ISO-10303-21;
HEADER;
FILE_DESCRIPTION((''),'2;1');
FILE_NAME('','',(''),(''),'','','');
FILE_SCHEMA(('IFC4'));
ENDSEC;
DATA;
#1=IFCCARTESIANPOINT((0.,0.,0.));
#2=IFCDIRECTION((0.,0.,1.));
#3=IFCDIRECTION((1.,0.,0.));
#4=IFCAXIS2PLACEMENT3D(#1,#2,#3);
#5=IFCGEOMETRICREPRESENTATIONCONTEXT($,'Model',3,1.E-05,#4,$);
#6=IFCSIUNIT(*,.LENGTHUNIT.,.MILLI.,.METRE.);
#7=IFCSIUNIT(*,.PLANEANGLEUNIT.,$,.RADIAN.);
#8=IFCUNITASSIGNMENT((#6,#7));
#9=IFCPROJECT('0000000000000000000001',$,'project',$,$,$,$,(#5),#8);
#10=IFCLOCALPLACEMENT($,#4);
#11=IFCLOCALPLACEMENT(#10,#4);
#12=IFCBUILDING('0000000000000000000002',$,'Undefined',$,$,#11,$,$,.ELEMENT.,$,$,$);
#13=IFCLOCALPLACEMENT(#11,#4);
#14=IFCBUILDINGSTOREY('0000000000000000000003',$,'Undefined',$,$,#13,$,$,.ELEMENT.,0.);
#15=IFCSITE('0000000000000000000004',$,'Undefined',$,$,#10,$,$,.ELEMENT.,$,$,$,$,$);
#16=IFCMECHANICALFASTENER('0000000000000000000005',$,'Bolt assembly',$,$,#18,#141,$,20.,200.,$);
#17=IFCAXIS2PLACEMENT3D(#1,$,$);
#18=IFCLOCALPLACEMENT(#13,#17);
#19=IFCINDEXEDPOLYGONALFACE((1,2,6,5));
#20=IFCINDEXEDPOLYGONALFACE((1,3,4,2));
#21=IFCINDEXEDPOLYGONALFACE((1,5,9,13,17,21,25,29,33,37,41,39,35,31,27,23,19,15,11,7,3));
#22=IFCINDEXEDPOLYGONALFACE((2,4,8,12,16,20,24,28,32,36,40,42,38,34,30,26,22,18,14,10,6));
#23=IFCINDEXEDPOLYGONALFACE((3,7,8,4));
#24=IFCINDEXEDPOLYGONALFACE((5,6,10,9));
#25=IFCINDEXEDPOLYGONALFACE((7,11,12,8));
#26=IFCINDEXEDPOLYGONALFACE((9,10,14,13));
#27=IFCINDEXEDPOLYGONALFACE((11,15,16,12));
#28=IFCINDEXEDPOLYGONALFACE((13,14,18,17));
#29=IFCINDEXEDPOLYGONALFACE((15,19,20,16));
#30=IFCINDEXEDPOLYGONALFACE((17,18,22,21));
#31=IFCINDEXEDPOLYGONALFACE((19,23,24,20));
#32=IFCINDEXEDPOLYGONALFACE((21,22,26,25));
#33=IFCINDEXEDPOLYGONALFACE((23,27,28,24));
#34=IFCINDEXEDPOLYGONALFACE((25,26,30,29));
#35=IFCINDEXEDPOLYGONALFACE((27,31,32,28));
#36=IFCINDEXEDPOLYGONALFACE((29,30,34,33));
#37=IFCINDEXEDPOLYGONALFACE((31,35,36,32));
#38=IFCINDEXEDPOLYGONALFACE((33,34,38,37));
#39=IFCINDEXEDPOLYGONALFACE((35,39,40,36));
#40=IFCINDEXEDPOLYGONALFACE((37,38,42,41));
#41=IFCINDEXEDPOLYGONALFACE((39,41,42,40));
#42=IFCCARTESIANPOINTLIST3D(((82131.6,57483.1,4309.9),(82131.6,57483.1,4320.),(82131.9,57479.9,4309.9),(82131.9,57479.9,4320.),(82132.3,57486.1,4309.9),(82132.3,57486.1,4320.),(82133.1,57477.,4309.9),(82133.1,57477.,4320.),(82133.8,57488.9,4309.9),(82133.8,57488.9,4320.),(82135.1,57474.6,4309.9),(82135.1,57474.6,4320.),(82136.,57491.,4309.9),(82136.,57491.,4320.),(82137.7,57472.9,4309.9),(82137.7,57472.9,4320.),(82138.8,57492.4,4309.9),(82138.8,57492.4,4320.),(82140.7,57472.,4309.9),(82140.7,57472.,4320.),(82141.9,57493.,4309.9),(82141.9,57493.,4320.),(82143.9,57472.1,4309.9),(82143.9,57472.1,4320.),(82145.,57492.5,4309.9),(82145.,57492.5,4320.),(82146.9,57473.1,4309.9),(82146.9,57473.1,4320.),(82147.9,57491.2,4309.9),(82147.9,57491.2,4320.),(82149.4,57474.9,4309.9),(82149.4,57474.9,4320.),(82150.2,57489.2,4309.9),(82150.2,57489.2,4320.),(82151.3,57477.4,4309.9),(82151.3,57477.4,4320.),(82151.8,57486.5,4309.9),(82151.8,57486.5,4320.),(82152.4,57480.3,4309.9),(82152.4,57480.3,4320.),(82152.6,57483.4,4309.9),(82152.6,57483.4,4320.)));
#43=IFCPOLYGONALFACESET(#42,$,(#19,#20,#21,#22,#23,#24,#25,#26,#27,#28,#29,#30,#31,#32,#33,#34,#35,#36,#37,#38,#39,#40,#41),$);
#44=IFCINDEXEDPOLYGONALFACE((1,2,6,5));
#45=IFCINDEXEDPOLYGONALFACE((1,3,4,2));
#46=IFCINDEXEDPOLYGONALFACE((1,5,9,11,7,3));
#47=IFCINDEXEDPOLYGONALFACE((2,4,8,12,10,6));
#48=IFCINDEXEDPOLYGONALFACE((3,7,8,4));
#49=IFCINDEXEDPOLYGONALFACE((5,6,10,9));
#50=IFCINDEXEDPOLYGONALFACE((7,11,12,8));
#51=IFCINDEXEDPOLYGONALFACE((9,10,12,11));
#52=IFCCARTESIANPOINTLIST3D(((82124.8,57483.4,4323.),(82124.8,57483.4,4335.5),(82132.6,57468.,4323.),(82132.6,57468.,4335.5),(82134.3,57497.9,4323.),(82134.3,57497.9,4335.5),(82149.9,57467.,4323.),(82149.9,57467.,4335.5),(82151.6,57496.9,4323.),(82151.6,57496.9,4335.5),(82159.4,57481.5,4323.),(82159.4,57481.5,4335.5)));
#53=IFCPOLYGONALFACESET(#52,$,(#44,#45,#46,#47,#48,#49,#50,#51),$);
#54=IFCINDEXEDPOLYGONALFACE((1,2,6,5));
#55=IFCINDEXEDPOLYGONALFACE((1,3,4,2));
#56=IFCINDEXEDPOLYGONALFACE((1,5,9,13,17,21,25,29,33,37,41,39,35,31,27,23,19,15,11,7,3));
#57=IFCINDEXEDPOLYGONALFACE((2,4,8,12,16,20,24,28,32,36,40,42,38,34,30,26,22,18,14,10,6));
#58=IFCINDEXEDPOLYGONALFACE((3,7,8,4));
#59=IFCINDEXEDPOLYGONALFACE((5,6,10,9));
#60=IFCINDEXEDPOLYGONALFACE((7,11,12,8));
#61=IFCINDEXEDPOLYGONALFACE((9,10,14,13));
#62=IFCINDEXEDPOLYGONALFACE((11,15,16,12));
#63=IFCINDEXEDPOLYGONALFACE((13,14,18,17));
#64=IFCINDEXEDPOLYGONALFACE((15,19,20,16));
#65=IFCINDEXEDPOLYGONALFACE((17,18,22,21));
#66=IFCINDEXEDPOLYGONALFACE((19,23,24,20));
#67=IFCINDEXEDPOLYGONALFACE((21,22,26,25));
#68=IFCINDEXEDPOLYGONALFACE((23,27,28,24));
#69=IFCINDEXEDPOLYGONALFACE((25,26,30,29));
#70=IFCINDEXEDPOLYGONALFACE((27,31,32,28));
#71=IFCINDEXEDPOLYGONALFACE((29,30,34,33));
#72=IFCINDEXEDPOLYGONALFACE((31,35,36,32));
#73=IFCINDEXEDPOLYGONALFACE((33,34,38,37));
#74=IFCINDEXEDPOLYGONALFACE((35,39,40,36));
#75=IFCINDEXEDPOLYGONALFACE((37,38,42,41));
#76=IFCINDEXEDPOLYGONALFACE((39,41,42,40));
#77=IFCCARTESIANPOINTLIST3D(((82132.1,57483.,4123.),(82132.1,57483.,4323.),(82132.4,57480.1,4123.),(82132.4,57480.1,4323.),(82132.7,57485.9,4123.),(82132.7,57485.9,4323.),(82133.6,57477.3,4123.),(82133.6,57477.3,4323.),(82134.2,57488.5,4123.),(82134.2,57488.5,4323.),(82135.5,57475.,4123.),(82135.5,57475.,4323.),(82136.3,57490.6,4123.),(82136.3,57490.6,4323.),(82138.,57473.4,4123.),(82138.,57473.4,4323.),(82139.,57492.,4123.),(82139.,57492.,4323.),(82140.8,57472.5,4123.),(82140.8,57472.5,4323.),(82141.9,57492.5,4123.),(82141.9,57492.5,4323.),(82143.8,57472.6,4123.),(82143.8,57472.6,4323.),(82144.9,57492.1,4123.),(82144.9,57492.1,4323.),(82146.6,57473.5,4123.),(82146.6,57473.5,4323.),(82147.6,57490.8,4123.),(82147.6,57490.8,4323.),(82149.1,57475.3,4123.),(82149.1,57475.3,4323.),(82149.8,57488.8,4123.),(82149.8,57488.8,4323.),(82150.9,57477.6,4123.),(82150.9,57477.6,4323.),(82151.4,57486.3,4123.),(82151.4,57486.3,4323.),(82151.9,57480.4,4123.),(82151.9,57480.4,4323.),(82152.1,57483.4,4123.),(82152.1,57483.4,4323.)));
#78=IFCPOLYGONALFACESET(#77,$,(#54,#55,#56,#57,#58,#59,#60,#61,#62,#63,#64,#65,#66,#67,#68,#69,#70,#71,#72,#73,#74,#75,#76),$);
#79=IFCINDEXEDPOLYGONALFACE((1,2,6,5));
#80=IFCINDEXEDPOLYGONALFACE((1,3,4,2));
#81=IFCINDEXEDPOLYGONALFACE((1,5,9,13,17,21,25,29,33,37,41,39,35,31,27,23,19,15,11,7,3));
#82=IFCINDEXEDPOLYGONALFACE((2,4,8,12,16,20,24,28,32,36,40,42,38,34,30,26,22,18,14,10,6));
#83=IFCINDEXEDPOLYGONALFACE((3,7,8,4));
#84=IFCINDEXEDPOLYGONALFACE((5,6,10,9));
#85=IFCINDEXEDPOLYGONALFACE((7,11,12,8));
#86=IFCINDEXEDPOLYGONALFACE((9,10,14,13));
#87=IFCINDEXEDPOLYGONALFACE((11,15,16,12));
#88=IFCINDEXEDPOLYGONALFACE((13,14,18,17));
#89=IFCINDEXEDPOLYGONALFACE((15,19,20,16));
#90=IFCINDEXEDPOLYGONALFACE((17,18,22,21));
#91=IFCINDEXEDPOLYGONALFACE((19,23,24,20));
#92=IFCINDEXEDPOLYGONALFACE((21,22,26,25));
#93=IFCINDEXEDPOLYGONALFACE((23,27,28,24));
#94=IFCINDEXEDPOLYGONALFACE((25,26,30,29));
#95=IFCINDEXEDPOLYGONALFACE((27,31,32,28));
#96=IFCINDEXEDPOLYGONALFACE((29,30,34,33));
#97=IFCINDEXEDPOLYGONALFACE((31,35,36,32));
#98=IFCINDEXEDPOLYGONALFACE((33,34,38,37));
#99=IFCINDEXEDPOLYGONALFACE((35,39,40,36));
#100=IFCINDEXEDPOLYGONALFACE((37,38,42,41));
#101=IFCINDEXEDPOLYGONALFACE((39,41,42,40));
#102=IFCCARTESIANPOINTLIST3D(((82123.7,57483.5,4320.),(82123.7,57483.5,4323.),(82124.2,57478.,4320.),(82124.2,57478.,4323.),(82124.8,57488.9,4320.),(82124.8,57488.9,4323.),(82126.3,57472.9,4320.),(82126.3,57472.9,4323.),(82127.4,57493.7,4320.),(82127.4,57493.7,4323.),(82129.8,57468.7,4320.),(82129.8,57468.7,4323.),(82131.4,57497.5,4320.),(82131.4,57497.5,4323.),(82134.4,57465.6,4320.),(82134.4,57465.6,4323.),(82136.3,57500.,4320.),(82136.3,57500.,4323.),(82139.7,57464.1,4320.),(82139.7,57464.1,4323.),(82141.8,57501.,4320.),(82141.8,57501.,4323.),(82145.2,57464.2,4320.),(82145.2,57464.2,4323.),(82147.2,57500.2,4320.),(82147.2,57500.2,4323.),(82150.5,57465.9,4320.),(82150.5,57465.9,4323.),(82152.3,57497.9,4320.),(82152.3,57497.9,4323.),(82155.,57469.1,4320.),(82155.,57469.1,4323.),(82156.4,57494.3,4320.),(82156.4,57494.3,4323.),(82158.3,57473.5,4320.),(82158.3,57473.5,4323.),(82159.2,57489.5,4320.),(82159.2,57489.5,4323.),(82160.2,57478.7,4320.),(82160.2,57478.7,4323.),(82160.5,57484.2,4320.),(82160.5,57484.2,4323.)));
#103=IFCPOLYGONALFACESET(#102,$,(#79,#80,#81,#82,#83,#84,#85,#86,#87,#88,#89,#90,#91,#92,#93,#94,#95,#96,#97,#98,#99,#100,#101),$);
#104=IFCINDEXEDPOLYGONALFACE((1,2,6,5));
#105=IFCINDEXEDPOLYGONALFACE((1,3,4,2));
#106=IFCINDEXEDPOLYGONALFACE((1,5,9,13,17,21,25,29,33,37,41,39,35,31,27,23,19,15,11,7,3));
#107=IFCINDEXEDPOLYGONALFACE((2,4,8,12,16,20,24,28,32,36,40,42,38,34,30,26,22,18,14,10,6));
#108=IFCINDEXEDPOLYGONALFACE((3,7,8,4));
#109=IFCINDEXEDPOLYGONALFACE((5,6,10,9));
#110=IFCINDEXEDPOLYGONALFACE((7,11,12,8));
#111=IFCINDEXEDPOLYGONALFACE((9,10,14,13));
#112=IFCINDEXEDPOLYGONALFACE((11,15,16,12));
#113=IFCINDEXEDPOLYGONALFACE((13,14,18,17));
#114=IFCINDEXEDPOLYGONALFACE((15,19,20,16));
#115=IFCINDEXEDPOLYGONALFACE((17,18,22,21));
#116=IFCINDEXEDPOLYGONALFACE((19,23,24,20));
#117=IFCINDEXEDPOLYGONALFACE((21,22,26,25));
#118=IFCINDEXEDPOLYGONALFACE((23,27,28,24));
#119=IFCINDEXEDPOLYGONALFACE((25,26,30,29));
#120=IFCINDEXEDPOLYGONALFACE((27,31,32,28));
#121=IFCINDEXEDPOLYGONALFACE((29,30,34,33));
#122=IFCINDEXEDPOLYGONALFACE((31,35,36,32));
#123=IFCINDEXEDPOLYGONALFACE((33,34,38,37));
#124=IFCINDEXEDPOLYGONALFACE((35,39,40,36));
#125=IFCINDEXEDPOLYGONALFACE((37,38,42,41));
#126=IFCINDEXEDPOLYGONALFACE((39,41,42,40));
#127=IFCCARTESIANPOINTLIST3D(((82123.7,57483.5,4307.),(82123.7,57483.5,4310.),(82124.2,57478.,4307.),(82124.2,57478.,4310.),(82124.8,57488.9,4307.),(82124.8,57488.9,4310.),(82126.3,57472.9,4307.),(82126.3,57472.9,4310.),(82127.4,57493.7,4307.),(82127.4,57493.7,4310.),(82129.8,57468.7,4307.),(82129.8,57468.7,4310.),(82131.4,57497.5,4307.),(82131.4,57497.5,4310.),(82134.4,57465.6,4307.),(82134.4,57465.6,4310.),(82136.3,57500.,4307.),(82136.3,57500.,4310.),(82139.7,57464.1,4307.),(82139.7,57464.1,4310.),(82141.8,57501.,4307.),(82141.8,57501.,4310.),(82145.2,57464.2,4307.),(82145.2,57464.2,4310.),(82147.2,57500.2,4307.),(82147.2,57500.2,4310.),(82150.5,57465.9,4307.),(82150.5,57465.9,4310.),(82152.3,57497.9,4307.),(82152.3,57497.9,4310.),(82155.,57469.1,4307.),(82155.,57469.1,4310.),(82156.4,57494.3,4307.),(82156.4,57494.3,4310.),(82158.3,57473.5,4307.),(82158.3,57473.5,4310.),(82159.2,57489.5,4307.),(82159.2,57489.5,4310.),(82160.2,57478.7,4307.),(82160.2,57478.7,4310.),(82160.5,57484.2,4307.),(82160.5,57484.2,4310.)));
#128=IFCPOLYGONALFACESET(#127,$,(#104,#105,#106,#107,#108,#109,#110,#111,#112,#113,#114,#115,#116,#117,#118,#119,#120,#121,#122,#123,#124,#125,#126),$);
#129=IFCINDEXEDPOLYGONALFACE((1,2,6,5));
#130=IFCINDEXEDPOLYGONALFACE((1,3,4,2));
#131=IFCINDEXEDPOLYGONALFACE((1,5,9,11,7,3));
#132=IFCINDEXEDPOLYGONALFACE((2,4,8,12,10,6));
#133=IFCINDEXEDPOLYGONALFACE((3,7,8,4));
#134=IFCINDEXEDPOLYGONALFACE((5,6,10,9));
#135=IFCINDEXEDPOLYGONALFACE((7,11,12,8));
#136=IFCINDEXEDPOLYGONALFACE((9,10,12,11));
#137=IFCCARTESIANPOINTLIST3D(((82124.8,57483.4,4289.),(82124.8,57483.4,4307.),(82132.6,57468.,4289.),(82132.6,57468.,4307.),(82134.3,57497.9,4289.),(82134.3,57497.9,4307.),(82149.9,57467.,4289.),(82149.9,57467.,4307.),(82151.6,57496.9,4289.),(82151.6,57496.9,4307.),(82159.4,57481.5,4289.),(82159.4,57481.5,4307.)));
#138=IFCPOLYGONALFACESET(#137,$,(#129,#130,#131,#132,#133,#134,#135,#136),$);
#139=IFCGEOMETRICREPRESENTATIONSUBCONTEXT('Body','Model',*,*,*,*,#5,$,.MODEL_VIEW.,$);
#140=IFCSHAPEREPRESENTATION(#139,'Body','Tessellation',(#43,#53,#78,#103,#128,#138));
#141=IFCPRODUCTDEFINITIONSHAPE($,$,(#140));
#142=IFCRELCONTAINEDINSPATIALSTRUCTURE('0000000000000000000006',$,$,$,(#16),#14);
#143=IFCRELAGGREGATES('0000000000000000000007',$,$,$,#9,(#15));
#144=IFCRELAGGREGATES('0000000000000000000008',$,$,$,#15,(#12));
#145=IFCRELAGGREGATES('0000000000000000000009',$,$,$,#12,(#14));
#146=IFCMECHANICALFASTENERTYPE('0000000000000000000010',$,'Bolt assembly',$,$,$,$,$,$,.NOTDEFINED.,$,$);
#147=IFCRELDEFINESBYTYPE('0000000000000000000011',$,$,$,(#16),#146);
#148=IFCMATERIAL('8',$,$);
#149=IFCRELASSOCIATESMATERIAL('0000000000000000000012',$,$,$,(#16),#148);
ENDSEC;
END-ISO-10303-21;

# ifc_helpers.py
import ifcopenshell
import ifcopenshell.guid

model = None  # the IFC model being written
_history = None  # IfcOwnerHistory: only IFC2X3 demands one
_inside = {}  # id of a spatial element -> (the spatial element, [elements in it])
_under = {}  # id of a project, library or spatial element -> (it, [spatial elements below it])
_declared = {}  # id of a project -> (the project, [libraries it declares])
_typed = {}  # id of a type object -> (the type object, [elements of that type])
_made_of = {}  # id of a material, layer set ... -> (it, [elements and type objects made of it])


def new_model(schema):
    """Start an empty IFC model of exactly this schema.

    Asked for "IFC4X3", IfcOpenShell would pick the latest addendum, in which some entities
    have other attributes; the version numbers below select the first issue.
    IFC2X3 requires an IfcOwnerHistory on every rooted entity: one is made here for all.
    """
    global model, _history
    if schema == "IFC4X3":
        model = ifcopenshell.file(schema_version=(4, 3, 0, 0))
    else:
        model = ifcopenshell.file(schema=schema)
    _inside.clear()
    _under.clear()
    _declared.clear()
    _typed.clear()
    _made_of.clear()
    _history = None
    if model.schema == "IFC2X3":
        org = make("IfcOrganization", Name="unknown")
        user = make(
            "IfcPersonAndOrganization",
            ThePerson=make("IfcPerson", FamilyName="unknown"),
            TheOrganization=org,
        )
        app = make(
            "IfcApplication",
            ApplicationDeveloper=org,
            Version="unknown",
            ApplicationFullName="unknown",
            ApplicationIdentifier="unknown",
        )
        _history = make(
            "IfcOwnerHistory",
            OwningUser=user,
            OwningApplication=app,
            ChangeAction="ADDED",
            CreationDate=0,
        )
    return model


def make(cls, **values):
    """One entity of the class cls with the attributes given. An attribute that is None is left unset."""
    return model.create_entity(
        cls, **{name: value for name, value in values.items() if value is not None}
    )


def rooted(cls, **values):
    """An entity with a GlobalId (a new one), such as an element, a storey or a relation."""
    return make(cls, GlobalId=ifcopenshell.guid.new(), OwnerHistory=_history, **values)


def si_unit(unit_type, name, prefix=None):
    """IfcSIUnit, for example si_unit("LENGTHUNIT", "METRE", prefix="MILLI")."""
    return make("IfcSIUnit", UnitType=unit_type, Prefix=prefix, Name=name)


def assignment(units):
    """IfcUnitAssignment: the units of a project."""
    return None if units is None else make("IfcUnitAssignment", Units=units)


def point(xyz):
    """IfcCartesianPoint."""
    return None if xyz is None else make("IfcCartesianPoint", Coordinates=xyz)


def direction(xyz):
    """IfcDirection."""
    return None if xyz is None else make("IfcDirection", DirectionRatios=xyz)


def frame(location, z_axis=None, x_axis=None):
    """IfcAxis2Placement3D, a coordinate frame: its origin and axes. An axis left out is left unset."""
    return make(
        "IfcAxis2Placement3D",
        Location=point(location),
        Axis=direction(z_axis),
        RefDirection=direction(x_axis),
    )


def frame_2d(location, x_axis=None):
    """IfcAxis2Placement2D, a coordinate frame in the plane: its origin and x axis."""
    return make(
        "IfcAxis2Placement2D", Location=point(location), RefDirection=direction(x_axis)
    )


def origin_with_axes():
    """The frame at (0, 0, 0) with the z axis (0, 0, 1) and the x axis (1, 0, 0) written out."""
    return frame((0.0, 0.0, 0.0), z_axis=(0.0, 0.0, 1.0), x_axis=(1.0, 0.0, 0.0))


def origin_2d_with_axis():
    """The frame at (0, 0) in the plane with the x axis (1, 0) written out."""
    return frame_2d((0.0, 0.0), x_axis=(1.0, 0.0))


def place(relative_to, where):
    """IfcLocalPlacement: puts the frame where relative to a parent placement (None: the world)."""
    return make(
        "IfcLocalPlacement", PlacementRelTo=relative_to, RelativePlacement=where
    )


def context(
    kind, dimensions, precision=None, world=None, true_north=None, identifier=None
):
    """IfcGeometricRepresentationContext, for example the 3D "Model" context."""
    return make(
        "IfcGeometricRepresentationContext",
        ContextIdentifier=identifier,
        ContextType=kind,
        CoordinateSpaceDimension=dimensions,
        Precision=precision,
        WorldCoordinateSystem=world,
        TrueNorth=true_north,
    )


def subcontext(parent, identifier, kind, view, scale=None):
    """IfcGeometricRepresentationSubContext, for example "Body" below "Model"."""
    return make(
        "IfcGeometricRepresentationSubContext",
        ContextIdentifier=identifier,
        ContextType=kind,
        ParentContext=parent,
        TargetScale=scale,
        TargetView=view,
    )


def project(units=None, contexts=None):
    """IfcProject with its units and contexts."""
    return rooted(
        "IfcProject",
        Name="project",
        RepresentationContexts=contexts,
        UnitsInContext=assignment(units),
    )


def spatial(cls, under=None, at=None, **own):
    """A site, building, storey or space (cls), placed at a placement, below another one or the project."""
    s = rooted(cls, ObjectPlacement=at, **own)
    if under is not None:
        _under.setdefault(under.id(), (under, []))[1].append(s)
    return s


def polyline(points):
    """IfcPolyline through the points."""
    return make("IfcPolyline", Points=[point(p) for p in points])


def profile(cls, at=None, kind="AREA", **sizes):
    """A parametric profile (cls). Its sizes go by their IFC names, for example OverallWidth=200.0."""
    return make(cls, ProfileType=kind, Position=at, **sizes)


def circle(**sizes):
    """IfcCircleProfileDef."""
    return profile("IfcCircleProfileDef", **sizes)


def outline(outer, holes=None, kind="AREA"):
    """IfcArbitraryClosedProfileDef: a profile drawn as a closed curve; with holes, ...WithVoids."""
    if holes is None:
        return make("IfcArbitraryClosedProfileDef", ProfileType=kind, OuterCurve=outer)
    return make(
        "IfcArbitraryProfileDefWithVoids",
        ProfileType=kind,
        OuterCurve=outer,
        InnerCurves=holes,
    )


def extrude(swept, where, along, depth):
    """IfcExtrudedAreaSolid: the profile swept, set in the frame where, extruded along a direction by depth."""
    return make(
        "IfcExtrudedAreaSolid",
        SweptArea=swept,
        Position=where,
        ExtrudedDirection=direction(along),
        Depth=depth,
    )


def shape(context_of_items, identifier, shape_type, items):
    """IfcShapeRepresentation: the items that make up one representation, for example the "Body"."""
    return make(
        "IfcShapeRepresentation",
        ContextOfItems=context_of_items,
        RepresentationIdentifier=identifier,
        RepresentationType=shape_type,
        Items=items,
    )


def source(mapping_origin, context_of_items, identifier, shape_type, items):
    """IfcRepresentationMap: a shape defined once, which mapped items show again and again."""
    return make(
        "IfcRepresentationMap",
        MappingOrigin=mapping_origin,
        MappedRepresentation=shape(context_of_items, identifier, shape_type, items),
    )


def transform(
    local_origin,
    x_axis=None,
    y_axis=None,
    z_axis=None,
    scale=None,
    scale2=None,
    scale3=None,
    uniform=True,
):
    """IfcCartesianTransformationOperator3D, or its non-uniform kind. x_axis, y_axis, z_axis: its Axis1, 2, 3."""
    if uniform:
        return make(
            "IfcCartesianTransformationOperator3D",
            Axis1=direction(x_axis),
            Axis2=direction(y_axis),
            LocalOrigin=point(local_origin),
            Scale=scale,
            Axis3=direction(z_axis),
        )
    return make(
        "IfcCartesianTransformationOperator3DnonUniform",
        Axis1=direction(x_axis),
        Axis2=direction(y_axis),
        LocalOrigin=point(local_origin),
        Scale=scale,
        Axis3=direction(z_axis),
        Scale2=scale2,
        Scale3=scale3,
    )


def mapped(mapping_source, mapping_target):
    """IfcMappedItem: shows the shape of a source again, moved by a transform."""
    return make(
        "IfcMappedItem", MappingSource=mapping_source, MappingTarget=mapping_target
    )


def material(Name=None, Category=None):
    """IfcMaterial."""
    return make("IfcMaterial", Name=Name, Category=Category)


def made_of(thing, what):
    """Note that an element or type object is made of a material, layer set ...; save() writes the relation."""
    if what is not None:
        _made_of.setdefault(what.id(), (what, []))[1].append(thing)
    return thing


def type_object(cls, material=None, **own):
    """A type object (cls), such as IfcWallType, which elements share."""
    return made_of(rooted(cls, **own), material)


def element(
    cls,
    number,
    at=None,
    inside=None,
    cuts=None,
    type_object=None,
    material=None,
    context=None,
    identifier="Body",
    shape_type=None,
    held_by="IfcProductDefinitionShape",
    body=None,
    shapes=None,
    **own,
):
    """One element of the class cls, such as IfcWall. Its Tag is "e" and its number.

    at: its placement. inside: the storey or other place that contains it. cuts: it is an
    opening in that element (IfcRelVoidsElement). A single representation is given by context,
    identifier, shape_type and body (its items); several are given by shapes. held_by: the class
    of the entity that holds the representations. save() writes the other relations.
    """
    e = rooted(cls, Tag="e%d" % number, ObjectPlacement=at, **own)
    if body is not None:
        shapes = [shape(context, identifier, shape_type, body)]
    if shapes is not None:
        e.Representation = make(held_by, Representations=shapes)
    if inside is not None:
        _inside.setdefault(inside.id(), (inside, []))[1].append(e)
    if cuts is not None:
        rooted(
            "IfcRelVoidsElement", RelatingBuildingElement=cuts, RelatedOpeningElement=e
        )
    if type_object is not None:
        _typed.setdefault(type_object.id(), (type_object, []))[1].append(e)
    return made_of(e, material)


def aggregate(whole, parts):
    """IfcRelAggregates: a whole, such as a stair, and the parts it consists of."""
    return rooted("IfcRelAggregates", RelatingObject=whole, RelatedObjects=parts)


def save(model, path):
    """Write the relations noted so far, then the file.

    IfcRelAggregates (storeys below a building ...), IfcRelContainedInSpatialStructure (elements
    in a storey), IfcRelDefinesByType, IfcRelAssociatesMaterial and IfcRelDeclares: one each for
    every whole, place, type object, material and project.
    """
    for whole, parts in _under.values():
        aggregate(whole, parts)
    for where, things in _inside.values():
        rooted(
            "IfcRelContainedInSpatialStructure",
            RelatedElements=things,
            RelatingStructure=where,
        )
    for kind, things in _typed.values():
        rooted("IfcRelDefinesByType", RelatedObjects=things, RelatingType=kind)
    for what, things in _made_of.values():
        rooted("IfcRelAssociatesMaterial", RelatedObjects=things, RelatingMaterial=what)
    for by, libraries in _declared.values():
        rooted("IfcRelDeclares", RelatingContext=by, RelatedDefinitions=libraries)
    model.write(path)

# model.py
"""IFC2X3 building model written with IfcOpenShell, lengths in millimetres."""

from ifc_helpers import new_model, si_unit, frame, origin_with_axes, origin_2d_with_axis, place, context, subcontext, project, spatial, polyline, circle, outline, extrude, source, transform, mapped, material, type_object, element, save


model = new_model("IFC2X3")

# Units and contexts
model_context = context("Model", 3, precision=1e-05, world=origin_with_axes())
body_context = subcontext(model_context, "Body", "Model", "MODEL_VIEW")
ifc_project = project(units=[si_unit("LENGTHUNIT", "METRE", prefix="MILLI"), si_unit("PLANEANGLEUNIT", "RADIAN")], contexts=[model_context])

# Site, building, storey
site_placement = place(None, origin_with_axes())
site = spatial("IfcSite", under=ifc_project, at=site_placement, Name="Undefined", CompositionType="ELEMENT")
building_placement = place(site_placement, origin_with_axes())
building = spatial("IfcBuilding", under=site, at=building_placement, Name="Undefined", CompositionType="ELEMENT")
storey_placement = place(building_placement, origin_with_axes())
storey = spatial("IfcBuildingStorey", under=building, at=storey_placement, Name="Undefined", CompositionType="ELEMENT", Elevation=0.0)

# Mechanical fastener
ifc_material_1 = material(Name="8")
mechanical_fastener_type = type_object("IfcMechanicalFastenerType", Name="Bolt assembly")
shared_shape_1 = source(origin_with_axes(), body_context, "Body", "SweptSolid", [
    extrude(circle(Radius=10.5, at=origin_2d_with_axis()), frame((0.0, 0.0, 0.0), z_axis=(0.0, 1.0, 0.0), x_axis=(1.0, 0.0, 0.0)), (0.0, 0.0, 1.0), 10.1),
    extrude(outline(polyline([(17.3, 0.0), (8.7, 15.0), (-8.7, 15.0), (-17.3, 0.0), (-8.7, -15.0), (8.7, -15.0), (17.3, 0.0)])), frame((0.0, -15.5, 0.0), z_axis=(0.0, 1.0, 0.0), x_axis=(1.0, 0.0, 0.0)), (0.0, 0.0, 1.0), 12.5),
    extrude(circle(Radius=10.0, at=origin_2d_with_axis()), frame((0.0, -3.0, 0.0), z_axis=(0.0, 1.0, 0.0), x_axis=(1.0, 0.0, 0.0)), (0.0, 0.0, 1.0), 200.0),
    extrude(circle(Radius=18.5, at=origin_2d_with_axis()), frame((0.0, -3.0, 0.0), z_axis=(0.0, 1.0, 0.0), x_axis=(1.0, 0.0, 0.0)), (0.0, 0.0, 1.0), 3.0),
    extrude(circle(Radius=18.5, at=origin_2d_with_axis()), frame((0.0, 10.0, 0.0), z_axis=(0.0, 1.0, 0.0), x_axis=(1.0, 0.0, 0.0)), (0.0, 0.0, 1.0), 3.0),
    extrude(outline(polyline([(17.3, 0.0), (8.7, 15.0), (-8.7, 15.0), (-17.3, 0.0), (-8.7, -15.0), (8.7, -15.0), (17.3, 0.0)])), frame((0.0, 13.0, 0.0), z_axis=(0.0, 1.0, 0.0), x_axis=(1.0, 0.0, 0.0)), (0.0, 0.0, 1.0), 18.0),
])
for number, where, z_axis, x_axis, name in (
    (1, (82142.1, 57482.5, 4320.0), (0.892799, 0.450455, 0.0), (0.450455, -0.892799, 0.0), "Bolt assembly"),
):
    element("IfcMechanicalFastener", number, at=place(storey_placement, frame(where, z_axis=z_axis, x_axis=x_axis)), inside=storey, type_object=mechanical_fastener_type, material=ifc_material_1, Name=name, NominalDiameter=20.0, NominalLength=200.0, context=body_context, shape_type="MappedRepresentation", body=[
        mapped(shared_shape_1, transform((0.0, 0.0, 0.0))),
    ])

save(model, "model.ifc")
